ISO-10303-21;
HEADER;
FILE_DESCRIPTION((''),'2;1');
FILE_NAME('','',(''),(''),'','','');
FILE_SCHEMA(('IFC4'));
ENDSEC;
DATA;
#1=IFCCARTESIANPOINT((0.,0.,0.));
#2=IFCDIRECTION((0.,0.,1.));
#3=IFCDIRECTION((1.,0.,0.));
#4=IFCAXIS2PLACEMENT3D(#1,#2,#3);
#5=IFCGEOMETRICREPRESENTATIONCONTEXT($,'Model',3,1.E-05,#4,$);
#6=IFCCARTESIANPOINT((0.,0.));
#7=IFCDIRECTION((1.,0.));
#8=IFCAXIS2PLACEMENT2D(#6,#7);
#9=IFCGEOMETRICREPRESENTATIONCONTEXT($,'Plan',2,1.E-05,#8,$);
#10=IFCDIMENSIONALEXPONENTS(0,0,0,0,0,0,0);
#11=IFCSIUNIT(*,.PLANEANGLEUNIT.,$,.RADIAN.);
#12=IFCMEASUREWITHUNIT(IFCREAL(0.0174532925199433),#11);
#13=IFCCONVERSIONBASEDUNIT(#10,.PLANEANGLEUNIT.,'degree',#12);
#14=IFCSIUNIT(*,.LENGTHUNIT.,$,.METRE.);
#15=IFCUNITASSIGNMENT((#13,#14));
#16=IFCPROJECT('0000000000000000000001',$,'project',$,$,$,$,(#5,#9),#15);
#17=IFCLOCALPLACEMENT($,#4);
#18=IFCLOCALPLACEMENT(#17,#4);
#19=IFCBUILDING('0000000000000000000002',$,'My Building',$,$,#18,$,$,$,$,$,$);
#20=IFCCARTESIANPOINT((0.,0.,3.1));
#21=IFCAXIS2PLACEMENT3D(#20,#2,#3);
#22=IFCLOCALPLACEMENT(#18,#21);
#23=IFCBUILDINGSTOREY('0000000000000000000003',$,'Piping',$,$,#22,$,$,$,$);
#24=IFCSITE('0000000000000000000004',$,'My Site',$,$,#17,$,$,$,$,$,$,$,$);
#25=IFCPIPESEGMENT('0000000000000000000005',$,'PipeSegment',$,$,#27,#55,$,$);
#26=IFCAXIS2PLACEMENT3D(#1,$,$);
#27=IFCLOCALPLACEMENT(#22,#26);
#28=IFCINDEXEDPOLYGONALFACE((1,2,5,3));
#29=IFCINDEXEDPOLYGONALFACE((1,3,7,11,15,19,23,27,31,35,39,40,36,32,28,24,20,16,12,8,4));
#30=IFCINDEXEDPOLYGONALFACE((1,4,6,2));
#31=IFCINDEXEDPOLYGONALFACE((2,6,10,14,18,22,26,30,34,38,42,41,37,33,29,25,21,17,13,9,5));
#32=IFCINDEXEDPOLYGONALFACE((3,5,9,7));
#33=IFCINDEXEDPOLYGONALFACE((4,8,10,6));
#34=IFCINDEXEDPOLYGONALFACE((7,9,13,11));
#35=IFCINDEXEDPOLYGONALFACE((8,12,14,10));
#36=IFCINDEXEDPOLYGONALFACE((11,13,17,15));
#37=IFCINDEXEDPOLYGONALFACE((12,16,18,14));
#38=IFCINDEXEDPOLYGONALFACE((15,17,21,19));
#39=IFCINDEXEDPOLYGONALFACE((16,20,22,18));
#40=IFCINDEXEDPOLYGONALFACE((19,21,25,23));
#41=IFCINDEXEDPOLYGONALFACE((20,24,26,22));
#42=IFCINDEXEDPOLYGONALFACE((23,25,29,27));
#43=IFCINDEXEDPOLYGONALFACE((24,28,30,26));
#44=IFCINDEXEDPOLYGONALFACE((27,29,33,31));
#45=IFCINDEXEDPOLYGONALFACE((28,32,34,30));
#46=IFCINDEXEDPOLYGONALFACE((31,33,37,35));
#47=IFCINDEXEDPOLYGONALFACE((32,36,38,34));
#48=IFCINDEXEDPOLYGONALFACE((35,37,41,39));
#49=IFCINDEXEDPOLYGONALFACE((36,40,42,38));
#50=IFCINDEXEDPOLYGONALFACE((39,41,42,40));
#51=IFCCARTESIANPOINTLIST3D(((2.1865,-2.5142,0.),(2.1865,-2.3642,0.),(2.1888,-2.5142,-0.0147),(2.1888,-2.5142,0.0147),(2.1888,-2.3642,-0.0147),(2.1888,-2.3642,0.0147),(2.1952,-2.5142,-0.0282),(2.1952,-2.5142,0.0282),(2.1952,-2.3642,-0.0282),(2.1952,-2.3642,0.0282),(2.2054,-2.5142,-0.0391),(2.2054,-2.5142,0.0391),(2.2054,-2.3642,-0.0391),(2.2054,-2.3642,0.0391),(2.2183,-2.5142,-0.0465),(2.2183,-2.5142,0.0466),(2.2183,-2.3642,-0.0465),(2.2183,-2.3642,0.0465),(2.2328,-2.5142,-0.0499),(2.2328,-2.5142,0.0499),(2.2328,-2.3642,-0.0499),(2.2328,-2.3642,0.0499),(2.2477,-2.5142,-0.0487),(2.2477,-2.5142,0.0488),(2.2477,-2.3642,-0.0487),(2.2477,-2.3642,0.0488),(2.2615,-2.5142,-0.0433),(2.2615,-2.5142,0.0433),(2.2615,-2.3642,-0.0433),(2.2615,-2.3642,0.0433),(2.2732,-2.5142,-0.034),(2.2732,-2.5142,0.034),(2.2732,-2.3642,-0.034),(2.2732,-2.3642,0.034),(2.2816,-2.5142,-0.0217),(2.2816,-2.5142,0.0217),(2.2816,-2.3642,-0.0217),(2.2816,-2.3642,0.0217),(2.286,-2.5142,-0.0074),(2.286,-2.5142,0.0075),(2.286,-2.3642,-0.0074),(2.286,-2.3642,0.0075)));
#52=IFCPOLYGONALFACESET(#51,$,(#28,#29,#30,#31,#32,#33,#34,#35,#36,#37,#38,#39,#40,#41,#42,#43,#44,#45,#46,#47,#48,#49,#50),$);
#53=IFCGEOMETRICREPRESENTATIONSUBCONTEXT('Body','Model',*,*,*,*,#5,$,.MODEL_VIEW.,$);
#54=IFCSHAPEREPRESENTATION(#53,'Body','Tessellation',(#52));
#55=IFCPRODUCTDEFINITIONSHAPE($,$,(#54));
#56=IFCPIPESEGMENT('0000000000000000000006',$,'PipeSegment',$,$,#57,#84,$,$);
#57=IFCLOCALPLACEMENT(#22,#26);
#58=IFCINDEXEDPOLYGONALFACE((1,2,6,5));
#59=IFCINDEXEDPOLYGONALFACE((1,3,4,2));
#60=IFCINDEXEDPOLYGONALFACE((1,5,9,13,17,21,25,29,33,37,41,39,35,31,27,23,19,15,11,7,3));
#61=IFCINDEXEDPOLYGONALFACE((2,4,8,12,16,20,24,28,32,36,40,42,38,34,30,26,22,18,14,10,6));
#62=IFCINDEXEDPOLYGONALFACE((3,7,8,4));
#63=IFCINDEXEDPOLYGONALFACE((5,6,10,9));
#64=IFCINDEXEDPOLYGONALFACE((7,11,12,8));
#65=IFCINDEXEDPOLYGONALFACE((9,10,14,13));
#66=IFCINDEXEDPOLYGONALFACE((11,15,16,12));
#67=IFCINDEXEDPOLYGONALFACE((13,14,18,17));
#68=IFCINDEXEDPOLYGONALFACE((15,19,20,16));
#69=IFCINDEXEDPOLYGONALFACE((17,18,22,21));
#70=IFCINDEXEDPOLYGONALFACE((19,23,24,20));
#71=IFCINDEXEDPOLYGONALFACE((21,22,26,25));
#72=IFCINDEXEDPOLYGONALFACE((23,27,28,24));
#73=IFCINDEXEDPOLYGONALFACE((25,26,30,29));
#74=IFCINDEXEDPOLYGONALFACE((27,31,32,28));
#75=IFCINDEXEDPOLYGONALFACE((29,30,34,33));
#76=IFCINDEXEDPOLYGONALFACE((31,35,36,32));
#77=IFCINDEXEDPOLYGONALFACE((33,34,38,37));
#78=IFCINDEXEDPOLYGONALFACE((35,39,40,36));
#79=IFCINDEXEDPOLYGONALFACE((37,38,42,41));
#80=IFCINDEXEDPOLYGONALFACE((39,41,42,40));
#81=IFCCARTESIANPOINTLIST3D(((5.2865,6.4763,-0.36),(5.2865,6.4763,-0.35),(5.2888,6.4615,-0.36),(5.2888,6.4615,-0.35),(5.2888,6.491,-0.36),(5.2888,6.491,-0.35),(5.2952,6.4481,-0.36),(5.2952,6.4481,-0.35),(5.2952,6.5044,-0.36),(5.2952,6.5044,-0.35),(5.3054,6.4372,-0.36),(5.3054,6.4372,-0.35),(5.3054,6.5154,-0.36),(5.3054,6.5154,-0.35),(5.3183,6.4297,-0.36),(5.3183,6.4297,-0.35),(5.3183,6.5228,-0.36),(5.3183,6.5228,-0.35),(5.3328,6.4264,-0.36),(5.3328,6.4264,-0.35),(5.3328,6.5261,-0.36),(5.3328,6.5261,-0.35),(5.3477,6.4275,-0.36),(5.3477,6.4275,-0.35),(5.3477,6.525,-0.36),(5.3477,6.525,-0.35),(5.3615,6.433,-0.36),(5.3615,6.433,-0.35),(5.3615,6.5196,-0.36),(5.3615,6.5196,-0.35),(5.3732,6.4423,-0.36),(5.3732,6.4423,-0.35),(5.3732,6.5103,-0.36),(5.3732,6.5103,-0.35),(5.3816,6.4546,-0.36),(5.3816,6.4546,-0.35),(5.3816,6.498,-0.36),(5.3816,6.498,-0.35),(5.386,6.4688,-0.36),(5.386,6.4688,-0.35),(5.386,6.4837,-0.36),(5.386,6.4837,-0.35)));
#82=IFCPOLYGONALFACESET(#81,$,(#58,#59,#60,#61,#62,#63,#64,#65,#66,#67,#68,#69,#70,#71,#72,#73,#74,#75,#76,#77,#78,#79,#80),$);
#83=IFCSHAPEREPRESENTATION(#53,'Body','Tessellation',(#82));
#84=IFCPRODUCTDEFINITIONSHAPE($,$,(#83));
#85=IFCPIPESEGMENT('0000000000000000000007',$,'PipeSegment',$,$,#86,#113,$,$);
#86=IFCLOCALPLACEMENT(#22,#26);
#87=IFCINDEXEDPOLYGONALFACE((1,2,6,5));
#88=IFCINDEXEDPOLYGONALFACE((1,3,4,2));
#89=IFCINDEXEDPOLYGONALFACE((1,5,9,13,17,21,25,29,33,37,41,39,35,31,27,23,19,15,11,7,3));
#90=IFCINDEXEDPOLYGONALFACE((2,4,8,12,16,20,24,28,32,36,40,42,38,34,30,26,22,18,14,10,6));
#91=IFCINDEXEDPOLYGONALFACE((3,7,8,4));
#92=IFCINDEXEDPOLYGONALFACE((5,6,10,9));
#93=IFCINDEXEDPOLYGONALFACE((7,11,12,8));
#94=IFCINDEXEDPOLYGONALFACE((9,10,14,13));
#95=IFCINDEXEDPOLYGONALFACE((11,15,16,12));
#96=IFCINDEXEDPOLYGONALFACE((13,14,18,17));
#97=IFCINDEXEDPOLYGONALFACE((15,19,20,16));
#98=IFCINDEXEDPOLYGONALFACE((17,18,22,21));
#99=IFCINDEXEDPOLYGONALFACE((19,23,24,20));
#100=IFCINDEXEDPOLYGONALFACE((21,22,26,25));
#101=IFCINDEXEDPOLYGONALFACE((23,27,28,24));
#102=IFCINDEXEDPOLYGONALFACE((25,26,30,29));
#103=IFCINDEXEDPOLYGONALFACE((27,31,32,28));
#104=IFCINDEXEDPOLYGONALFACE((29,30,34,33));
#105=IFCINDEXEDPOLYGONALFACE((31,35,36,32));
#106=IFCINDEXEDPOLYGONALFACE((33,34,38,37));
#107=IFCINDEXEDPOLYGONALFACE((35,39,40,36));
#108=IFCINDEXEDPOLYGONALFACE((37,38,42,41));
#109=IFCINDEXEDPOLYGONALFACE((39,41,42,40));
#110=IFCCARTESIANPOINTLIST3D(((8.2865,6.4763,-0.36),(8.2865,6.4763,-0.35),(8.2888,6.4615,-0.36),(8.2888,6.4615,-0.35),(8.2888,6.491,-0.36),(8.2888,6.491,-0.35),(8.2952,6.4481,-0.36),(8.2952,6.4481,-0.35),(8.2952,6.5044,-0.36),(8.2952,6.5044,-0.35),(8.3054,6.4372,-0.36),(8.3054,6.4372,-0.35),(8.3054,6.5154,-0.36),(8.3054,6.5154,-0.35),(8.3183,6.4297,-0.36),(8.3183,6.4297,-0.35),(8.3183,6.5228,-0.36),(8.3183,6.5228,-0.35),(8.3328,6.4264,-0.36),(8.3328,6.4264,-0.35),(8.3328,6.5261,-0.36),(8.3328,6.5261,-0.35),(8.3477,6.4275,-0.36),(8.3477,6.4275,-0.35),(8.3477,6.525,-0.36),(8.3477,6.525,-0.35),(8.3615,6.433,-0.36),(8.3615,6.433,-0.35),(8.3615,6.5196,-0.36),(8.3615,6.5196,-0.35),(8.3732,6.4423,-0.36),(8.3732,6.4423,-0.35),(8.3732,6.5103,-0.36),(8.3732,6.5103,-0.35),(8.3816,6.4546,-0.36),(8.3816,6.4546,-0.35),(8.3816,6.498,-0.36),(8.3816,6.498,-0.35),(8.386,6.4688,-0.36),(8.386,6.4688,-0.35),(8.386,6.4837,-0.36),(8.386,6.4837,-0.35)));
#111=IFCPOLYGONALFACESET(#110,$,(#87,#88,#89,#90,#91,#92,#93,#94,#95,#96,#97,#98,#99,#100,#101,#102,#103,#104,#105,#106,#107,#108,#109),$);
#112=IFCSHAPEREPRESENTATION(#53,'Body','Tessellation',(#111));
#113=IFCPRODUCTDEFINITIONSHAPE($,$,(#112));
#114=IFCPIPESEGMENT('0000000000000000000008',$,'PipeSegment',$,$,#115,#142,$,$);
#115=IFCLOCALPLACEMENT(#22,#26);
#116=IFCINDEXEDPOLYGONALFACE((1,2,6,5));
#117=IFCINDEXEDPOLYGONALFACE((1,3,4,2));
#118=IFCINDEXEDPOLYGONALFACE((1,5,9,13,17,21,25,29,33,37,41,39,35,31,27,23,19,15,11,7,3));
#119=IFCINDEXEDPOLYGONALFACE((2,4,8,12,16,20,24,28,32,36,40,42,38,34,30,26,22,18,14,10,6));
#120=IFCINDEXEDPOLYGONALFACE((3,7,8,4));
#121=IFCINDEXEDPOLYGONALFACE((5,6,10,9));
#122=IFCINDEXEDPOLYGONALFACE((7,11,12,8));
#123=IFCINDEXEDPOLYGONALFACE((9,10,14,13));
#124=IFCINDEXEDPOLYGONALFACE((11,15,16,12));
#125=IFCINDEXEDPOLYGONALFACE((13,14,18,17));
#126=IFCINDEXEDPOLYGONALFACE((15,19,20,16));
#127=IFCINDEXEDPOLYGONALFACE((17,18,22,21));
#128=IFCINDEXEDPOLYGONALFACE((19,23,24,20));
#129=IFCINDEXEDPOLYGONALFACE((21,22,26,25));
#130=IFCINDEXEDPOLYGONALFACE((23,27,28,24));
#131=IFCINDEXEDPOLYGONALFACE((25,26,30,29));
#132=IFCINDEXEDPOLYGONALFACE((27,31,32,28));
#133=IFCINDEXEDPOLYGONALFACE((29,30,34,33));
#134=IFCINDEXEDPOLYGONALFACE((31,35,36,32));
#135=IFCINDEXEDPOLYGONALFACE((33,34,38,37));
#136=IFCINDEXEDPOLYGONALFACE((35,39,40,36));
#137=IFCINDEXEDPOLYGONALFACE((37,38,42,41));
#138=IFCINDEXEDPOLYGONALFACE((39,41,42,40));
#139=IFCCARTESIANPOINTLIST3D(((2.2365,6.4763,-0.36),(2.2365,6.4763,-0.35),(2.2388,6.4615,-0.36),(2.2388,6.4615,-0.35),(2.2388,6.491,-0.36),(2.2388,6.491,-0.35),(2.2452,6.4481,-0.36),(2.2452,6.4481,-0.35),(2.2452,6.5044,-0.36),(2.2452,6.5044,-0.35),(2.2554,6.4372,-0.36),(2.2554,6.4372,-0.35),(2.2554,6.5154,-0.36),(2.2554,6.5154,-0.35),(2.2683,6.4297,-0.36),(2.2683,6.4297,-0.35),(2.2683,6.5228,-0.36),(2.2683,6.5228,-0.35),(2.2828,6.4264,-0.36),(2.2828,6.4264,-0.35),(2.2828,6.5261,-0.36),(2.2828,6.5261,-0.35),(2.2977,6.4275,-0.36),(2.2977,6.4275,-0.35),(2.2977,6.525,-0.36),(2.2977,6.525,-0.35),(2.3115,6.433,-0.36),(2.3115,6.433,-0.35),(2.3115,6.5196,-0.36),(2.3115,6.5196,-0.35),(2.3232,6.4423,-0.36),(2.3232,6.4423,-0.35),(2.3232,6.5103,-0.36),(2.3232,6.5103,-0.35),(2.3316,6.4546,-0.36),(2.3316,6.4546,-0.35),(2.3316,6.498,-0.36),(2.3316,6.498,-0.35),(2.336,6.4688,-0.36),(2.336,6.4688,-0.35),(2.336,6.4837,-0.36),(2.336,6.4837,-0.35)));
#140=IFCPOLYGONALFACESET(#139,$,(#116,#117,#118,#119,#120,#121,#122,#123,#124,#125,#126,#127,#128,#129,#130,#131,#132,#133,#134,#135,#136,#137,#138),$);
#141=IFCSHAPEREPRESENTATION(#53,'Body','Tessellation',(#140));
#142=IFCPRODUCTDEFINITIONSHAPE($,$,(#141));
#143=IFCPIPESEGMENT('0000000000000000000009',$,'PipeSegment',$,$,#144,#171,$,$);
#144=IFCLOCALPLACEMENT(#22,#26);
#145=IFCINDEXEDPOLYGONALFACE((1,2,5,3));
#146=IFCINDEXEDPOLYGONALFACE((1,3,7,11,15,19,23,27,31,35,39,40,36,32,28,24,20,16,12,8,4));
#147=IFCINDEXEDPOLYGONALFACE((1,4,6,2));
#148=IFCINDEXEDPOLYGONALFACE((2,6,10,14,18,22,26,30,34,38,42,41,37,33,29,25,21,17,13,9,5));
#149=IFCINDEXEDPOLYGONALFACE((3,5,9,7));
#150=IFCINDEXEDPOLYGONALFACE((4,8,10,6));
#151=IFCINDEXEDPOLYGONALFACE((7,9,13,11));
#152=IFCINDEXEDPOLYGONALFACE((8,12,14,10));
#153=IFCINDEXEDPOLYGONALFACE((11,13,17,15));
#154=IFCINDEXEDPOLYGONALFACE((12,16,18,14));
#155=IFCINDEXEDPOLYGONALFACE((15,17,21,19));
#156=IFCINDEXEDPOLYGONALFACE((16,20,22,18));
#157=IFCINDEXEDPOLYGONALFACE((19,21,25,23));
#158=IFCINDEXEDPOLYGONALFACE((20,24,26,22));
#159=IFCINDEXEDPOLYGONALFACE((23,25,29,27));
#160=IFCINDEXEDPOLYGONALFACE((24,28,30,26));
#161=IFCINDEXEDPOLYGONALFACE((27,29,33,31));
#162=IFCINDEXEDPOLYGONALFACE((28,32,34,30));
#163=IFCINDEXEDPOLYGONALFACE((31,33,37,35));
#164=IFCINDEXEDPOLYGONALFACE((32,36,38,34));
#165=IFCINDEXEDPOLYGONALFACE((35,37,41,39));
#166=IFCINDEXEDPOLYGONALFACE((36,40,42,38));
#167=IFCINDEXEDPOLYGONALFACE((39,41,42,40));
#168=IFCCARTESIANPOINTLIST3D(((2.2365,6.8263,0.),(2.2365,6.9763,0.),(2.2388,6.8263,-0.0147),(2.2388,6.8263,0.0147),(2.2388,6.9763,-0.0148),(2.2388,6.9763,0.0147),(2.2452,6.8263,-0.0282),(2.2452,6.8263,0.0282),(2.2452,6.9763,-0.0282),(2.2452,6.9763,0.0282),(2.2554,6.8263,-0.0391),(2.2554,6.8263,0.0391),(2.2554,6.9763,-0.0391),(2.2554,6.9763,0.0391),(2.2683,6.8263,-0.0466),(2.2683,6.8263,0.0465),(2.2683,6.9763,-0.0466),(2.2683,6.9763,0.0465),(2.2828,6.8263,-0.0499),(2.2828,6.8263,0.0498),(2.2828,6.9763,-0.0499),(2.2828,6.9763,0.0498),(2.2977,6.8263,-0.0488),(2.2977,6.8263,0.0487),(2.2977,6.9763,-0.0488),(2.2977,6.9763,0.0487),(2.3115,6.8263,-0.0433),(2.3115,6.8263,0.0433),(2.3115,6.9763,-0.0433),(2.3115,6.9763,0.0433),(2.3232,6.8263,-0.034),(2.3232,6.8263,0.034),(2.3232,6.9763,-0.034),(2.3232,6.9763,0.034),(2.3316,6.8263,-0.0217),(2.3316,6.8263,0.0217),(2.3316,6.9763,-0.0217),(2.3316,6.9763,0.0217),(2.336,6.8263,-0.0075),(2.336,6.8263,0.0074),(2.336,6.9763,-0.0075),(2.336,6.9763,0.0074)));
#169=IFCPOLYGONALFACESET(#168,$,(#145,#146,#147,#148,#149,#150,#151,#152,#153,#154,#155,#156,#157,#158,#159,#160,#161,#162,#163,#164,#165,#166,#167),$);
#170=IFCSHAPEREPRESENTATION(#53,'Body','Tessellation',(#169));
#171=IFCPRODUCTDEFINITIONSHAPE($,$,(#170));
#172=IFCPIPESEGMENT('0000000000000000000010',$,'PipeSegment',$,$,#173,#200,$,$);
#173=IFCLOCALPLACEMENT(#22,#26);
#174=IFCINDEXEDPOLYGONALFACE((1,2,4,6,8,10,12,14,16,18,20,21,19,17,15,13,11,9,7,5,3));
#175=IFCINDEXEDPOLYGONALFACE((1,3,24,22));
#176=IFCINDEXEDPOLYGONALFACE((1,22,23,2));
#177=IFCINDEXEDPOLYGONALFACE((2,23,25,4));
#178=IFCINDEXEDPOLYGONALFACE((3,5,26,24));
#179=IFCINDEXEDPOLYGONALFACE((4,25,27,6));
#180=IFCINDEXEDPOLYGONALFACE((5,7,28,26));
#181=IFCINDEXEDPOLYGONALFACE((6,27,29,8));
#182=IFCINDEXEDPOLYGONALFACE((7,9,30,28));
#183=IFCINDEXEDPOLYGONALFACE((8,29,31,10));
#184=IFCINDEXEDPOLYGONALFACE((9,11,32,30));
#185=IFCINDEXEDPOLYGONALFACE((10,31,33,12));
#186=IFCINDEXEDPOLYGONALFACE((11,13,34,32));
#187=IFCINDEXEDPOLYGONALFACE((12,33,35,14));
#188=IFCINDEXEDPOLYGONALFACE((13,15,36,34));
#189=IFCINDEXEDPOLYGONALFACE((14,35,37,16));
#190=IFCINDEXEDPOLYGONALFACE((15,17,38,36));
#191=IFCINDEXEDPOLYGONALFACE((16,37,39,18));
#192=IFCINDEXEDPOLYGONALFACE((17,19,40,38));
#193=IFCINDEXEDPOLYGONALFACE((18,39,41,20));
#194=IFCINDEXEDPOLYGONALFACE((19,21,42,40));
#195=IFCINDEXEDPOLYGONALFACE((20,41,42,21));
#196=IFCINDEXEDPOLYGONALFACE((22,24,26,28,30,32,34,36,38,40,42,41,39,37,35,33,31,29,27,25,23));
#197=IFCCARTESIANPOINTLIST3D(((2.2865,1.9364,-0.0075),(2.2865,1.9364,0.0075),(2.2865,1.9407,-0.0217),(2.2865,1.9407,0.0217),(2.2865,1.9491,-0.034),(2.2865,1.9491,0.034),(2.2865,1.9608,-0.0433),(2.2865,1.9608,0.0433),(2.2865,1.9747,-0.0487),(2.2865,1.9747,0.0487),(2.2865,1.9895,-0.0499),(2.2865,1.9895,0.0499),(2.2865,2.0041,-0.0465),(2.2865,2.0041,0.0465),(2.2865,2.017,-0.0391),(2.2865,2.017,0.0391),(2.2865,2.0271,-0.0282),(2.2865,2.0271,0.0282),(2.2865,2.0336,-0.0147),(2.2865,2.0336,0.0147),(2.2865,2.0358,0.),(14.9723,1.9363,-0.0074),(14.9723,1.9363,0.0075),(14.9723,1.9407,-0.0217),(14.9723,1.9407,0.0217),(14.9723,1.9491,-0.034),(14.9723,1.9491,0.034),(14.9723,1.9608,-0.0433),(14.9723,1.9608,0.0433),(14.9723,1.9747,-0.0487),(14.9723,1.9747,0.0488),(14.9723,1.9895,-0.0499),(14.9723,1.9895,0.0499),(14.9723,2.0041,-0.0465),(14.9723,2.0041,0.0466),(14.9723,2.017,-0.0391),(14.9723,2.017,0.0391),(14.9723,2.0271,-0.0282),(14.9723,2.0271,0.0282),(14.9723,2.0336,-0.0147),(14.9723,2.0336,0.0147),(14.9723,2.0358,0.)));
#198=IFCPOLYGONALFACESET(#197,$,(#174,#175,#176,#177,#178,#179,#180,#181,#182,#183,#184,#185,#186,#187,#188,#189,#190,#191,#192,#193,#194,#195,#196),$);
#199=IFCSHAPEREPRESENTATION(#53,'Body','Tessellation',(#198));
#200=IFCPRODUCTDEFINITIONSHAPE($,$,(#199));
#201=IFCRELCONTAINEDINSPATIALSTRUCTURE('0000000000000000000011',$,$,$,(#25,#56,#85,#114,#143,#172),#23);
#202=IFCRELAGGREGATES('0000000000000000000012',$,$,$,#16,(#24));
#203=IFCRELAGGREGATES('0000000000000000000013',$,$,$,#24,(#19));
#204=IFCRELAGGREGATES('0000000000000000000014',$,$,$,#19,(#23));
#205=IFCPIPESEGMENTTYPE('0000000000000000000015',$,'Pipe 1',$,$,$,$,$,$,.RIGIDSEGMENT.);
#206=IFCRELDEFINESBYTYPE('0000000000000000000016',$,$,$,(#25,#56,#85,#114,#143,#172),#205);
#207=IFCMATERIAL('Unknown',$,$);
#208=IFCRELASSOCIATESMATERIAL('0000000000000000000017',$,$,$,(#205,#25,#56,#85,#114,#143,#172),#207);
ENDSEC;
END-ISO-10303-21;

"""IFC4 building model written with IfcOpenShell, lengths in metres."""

from ifc_helpers import new_model, entity, si_unit, converted_unit, frame, origin_with_axes, origin_2d_with_axis, place, context, subcontext, project, spatial, circle, extrude, material, material_profile, profile_set, profile_usage, type_object, element, save


model = new_model("IFC4")

# Units and contexts
model_context = context("Model", 3, precision=1e-05, world=origin_with_axes())
plan_context = context("Plan", 2, precision=1e-05, world=origin_2d_with_axis())
body_context = subcontext(model_context, "Body", "Model", "MODEL_VIEW")
ifc_project = project(units=[converted_unit("PLANEANGLEUNIT", "degree", entity("IfcReal", 0.0174532925199433), si_unit("PLANEANGLEUNIT", "RADIAN"), dimensions=[0, 0, 0, 0, 0, 0, 0]), si_unit("LENGTHUNIT", "METRE")], contexts=[model_context, plan_context])

# Site, building, storey
site_placement = place(None, origin_with_axes())
site = spatial("IfcSite", under=ifc_project, at=site_placement, Name="My Site")
building_placement = place(site_placement, origin_with_axes())
building = spatial("IfcBuilding", under=site, at=building_placement, Name="My Building")
storey_placement = place(building_placement, frame((0.0, 0.0, 3.1), z_axis=(0.0, 0.0, 1.0), x_axis=(1.0, 0.0, 0.0)))
storey = spatial("IfcBuildingStorey", under=building, at=storey_placement, Name="Piping")

# Pipe segments
ifc_material = material(Name="Unknown")
ifc_material_profile = material_profile(ifc_material, circle(Radius=0.05))
ifc_profile_set = profile_set([ifc_material_profile])
pipe_segment_type = type_object("IfcPipeSegmentType", Name="Pipe 1", PredefinedType="RIGIDSEGMENT", material=ifc_profile_set)
ifc_profile_usage_1 = profile_usage(ifc_profile_set, cardinal=5)
pipe_segment_1_placement = place(storey_placement, frame((2.2365, -2.5142, 0.0), z_axis=(0.0, 1.0, -0.000022), x_axis=(-1.0, 0.0, 0.0)))
element("IfcPipeSegment", 1, at=pipe_segment_1_placement, inside=storey, type_object=pipe_segment_type, material=ifc_profile_usage_1, Name="PipeSegment", context=body_context, shape_type="SweptSolid", body=[
    extrude(circle(Radius=0.05), origin_with_axes(), (0.0, 0.0, 1.0), 0.15),
])
ifc_profile_usage_2 = profile_usage(ifc_profile_set, cardinal=5)
pipe_segment_2_placement = place(storey_placement, frame((5.3365, 6.4763, -0.35), z_axis=(0.0, 0.0, -1.0), x_axis=(-1.0, 0.0, 0.0)))
element("IfcPipeSegment", 2, at=pipe_segment_2_placement, inside=storey, type_object=pipe_segment_type, material=ifc_profile_usage_2, Name="PipeSegment", context=body_context, shape_type="SweptSolid", body=[
    extrude(circle(Radius=0.05), origin_with_axes(), (0.0, 0.0, 1.0), 0.01),
])
ifc_profile_usage_3 = profile_usage(ifc_profile_set, cardinal=5)
pipe_segment_3_placement = place(storey_placement, frame((8.3365, 6.4763, -0.35), z_axis=(0.0, 0.0, -1.0), x_axis=(-1.0, 0.0, 0.0)))
element("IfcPipeSegment", 3, at=pipe_segment_3_placement, inside=storey, type_object=pipe_segment_type, material=ifc_profile_usage_3, Name="PipeSegment", context=body_context, shape_type="SweptSolid", body=[
    extrude(circle(Radius=0.05), origin_with_axes(), (0.0, 0.0, 1.0), 0.01),
])
ifc_profile_usage_4 = profile_usage(ifc_profile_set, cardinal=5)
pipe_segment_4_placement = place(storey_placement, frame((2.2865, 6.4763, -0.35), z_axis=(0.0, 0.0, -1.0), x_axis=(-1.0, 0.0, 0.0)))
element("IfcPipeSegment", 4, at=pipe_segment_4_placement, inside=storey, type_object=pipe_segment_type, material=ifc_profile_usage_4, Name="PipeSegment", context=body_context, shape_type="SweptSolid", body=[
    extrude(circle(Radius=0.05), origin_with_axes(), (0.0, 0.0, 1.0), 0.01),
])
ifc_profile_usage_5 = profile_usage(ifc_profile_set, cardinal=5)
pipe_segment_5_placement = place(storey_placement, frame((2.2865, 6.8263, 0.0), z_axis=(0.0, 1.0, -0.000022), x_axis=(-1.0, 0.0, 0.0)))
element("IfcPipeSegment", 5, at=pipe_segment_5_placement, inside=storey, type_object=pipe_segment_type, material=ifc_profile_usage_5, Name="PipeSegment", context=body_context, shape_type="SweptSolid", body=[
    extrude(circle(Radius=0.05), origin_with_axes(), (0.0, 0.0, 1.0), 0.15),
])
ifc_profile_usage_6 = profile_usage(ifc_profile_set, cardinal=5)
pipe_segment_6_placement = place(storey_placement, frame((2.2865, 1.9858, 0.0), z_axis=(1.0, 0.0, 0.0), x_axis=(0.0, 1.0, 0.0)))
element("IfcPipeSegment", 6, at=pipe_segment_6_placement, inside=storey, type_object=pipe_segment_type, material=ifc_profile_usage_6, Name="PipeSegment", context=body_context, shape_type="SweptSolid", body=[
    extrude(circle(Radius=0.05), origin_with_axes(), (0.0, 0.0, 1.0), 12.6858),
])

save(model, "model.ifc")
